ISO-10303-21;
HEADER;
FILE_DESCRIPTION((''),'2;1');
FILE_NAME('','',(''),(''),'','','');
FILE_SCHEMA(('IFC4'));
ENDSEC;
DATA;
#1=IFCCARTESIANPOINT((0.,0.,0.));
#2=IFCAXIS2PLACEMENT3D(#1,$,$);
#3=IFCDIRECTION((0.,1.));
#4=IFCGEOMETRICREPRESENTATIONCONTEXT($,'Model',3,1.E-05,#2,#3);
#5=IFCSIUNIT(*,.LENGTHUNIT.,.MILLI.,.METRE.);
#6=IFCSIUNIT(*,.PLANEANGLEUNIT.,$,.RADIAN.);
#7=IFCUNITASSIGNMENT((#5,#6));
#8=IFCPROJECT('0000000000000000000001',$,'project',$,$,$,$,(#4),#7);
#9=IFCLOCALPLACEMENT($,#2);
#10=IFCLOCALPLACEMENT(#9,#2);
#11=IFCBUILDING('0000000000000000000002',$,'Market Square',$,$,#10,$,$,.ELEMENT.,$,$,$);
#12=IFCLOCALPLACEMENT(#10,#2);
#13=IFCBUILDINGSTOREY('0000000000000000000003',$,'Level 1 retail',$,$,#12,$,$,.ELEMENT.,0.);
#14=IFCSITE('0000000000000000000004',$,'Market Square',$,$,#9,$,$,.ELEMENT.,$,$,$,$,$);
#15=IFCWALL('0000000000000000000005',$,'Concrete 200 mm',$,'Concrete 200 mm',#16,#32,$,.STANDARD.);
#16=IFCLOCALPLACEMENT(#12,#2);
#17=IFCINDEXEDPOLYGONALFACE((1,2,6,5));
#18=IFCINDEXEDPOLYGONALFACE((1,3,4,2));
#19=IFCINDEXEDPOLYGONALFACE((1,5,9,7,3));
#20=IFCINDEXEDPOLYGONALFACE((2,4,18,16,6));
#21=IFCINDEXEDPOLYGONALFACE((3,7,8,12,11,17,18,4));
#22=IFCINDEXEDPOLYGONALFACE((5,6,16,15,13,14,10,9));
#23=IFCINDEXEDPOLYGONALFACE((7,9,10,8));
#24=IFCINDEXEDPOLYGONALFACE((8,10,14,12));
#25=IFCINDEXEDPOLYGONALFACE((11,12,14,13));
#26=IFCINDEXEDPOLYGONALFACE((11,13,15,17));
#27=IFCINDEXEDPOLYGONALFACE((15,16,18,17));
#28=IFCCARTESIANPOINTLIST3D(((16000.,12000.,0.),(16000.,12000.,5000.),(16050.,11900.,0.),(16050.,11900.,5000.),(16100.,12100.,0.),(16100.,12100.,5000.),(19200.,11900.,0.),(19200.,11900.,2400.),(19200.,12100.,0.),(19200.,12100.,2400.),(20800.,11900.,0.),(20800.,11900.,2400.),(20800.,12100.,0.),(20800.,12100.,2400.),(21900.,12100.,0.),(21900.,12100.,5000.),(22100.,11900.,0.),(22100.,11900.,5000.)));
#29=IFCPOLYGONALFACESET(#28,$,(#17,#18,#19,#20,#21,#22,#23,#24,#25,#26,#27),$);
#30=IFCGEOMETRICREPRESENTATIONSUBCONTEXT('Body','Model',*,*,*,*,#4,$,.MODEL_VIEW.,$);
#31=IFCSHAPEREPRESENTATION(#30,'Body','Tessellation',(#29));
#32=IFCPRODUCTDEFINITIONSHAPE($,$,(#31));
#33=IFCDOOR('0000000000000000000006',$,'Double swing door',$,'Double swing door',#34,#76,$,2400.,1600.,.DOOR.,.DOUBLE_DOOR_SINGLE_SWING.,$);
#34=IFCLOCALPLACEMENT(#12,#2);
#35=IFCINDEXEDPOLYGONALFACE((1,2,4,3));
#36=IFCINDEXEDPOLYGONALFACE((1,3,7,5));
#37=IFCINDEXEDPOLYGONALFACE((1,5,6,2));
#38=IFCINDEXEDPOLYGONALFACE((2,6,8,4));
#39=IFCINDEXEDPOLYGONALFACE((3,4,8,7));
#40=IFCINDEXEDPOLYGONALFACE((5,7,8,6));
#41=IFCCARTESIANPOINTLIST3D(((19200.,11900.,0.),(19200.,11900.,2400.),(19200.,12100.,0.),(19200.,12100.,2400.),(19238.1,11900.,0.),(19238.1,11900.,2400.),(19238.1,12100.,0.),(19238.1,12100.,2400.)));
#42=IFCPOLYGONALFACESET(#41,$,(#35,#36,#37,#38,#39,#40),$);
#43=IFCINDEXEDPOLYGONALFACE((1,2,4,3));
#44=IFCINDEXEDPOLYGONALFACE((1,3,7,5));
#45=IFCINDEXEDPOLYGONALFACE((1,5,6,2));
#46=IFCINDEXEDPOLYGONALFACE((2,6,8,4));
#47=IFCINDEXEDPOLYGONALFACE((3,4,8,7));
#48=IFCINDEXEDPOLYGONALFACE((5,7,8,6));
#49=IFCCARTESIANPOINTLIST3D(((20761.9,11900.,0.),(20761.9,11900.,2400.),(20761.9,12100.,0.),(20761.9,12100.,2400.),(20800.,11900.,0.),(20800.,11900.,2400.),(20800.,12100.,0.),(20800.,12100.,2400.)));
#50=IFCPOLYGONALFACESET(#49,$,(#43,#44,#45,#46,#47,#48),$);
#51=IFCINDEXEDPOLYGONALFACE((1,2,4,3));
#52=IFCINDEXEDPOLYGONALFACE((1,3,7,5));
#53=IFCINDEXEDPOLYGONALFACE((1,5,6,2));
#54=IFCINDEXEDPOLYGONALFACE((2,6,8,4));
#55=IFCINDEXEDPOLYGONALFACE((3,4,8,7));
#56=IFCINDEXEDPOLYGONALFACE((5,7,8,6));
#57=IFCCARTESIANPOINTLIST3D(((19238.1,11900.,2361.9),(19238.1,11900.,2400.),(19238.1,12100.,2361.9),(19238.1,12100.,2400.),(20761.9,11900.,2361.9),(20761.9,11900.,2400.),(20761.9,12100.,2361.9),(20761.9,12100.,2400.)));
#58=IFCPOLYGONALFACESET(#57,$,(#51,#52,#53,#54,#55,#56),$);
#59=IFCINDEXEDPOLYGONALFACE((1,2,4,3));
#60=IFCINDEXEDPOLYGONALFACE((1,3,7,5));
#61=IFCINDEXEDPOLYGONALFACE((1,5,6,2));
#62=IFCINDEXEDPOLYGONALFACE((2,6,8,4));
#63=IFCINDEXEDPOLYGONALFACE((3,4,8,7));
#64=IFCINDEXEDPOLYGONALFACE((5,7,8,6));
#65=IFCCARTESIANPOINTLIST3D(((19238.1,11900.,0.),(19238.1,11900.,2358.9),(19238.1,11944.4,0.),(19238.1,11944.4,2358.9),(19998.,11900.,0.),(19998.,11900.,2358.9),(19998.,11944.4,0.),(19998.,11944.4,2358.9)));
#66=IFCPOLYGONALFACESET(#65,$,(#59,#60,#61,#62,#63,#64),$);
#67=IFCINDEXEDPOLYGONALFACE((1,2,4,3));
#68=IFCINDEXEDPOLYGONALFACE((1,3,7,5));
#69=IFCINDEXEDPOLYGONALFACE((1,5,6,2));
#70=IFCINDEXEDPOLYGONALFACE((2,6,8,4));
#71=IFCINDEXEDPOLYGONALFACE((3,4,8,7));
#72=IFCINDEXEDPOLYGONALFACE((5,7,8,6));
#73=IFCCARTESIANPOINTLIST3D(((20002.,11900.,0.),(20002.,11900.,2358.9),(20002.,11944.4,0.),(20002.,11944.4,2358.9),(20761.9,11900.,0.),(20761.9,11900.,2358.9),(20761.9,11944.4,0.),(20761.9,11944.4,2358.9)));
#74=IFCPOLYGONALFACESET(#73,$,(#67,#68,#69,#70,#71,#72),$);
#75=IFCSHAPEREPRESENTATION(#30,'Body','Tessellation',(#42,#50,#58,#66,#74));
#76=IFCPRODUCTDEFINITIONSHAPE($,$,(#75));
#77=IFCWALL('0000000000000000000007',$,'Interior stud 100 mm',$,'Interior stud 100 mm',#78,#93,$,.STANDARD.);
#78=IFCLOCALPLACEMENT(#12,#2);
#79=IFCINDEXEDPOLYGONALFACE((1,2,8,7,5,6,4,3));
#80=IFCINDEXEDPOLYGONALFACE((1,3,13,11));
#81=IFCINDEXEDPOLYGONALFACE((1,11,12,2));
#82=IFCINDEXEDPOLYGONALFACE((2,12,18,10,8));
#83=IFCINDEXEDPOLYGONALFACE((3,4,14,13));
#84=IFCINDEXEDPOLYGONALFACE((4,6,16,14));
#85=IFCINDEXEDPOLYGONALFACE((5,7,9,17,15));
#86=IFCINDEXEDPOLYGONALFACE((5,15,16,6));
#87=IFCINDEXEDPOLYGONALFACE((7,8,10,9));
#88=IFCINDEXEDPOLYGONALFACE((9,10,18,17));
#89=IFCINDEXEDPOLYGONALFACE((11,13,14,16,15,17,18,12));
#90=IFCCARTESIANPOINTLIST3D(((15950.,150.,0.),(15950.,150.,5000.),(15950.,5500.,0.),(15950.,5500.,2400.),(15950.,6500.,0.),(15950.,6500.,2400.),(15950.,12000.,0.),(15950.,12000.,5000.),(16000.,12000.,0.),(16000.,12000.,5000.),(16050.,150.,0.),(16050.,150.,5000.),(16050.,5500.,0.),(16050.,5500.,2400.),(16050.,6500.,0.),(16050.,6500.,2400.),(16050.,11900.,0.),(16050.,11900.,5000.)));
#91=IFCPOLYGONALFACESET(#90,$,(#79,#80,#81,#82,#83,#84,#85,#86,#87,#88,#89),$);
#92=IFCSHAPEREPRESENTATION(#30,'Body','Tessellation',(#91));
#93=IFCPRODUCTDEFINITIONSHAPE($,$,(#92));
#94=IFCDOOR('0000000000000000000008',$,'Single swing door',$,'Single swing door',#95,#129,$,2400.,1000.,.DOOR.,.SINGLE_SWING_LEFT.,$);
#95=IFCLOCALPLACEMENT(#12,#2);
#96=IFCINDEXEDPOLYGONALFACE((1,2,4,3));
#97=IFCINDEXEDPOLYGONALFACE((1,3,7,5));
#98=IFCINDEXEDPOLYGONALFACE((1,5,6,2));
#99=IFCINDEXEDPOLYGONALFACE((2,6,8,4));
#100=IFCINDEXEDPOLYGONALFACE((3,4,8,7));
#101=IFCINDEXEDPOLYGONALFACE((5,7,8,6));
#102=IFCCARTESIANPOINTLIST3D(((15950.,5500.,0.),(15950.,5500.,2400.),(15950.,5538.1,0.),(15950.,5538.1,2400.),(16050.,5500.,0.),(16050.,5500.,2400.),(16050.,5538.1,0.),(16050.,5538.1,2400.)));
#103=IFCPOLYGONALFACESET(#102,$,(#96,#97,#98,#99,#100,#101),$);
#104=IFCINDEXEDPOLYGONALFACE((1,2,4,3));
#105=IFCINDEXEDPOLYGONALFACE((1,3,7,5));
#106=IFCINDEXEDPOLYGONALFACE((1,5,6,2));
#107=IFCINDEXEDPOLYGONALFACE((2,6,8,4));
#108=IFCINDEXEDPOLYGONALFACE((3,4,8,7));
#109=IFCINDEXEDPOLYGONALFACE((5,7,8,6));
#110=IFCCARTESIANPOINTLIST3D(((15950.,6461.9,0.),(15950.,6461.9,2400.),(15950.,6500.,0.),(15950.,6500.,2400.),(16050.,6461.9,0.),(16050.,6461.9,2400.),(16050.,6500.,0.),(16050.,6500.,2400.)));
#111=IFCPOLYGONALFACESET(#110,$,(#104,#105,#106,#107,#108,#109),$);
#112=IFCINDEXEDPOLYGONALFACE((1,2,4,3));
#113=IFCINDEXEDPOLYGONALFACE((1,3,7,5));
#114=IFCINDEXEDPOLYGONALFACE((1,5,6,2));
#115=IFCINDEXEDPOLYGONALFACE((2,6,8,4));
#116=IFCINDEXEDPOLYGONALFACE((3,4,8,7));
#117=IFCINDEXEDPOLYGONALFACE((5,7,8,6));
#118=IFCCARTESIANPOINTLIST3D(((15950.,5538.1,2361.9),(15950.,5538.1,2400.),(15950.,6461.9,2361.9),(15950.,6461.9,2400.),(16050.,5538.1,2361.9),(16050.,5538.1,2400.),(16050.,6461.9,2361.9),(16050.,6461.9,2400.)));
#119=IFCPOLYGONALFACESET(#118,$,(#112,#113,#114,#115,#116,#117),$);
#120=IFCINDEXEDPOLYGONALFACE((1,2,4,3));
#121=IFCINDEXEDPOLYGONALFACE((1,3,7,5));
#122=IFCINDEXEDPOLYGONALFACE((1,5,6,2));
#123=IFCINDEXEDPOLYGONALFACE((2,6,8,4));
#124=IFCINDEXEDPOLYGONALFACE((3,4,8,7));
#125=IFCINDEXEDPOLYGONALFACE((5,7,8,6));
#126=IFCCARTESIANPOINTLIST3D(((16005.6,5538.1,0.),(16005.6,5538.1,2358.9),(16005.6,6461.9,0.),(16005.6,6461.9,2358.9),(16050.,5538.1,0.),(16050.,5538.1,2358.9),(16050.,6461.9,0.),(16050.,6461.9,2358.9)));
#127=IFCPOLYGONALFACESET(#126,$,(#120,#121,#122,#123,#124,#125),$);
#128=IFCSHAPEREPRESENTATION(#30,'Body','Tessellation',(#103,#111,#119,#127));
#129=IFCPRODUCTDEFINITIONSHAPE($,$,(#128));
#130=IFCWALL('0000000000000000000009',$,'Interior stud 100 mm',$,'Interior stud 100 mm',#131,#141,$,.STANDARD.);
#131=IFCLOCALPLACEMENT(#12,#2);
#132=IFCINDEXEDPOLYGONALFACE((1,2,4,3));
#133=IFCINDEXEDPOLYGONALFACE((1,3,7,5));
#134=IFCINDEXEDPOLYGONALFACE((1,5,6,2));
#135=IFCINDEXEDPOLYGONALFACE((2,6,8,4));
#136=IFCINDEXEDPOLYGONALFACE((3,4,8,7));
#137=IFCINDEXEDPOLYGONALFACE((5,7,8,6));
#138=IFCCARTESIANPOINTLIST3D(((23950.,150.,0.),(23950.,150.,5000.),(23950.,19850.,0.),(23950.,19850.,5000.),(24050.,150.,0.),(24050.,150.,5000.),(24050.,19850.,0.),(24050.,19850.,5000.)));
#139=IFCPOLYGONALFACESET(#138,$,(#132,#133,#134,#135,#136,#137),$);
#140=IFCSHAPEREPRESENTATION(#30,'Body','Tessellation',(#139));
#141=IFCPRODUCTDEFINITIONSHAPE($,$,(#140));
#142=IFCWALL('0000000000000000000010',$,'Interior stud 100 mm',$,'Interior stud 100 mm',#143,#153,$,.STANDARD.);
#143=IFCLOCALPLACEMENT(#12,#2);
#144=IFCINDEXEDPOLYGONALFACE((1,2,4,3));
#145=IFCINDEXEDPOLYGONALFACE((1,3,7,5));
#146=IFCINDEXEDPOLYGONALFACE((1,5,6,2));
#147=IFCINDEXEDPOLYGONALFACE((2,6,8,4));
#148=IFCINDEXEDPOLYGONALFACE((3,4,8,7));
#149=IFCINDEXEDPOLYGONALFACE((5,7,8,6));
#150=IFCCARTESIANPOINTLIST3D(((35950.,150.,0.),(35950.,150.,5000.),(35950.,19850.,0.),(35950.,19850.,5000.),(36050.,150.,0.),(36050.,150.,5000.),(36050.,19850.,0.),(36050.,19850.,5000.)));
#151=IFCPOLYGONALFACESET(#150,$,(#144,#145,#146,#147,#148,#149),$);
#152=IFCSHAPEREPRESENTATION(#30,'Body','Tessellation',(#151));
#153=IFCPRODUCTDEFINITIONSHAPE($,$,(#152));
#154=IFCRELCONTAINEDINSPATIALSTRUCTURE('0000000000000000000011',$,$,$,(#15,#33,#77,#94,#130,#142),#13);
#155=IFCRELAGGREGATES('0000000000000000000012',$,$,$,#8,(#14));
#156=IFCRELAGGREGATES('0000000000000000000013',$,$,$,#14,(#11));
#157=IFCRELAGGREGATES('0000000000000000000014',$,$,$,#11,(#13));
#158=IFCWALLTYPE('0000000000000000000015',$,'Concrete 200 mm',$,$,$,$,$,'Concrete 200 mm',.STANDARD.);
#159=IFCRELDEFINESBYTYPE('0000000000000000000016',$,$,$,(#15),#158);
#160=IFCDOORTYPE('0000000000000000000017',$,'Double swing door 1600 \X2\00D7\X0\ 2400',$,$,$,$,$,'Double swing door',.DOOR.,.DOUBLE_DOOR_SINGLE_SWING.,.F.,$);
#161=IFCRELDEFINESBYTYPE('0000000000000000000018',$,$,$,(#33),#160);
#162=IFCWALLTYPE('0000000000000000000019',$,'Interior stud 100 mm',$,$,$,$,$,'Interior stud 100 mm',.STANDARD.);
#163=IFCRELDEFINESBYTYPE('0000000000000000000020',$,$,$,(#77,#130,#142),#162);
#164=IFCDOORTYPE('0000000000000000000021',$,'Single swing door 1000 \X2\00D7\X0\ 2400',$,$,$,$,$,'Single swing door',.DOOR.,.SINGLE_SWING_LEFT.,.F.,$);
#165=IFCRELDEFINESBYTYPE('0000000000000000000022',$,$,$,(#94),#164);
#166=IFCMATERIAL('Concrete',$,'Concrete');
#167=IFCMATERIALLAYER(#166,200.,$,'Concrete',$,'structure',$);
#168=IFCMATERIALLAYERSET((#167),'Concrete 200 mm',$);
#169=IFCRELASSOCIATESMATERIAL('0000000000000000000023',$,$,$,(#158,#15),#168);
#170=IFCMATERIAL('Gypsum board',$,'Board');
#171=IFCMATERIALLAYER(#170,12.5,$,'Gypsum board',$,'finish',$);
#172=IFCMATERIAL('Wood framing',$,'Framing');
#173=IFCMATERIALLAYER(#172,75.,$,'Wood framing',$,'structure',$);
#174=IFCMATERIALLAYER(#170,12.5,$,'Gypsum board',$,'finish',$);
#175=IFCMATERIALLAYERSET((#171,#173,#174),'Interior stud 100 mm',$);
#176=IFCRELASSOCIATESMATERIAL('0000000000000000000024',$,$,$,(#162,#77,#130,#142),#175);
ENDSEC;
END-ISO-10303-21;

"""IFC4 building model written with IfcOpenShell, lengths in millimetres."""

from ifc_helpers import new_model, si_unit, direction, frame, origin, origin_with_axes, place, context, subcontext, project, spatial, polyline, outline, extrude, material, layer, layer_set, layer_usage, type_object, element, fill, save


model = new_model("IFC4")

# Units and contexts
model_context = context("Model", 3, precision=1e-05, world=origin(), true_north=direction((0.0, 1.0)))
body_context = subcontext(model_context, "Body", "Model", "MODEL_VIEW")
ifc_project = project(units=[si_unit("LENGTHUNIT", "METRE", prefix="MILLI"), si_unit("PLANEANGLEUNIT", "RADIAN")], contexts=[model_context])

# Site, building, storey
site_placement = place(None, origin())
site = spatial("IfcSite", under=ifc_project, at=site_placement, Name="Market Square", CompositionType="ELEMENT")
building_placement = place(site_placement, origin())
building = spatial("IfcBuilding", under=site, at=building_placement, Name="Market Square", CompositionType="ELEMENT")
storey_placement = place(building_placement, origin())
storey = spatial("IfcBuildingStorey", under=building, at=storey_placement, Name="Level 1 retail", CompositionType="ELEMENT", Elevation=0.0)

# Shared definitions
door_type_1 = type_object("IfcDoorType", Name="Single swing door 1000 × 2400", ElementType="Single swing door", OperationType="SINGLE_SWING_LEFT", ParameterTakesPrecedence=False, PredefinedType="DOOR")

# Shared definitions
ifc_material_1 = material(Name="Concrete", Category="Concrete")
ifc_layer_1 = layer(ifc_material_1, 200.0, Name="Concrete", Category="structure")
ifc_layer_set_1 = layer_set([ifc_layer_1], Name="Concrete 200 mm")
wall_type_1 = type_object("IfcWallType", Name="Concrete 200 mm", ElementType="Concrete 200 mm", PredefinedType="STANDARD", material=ifc_layer_set_1)

# Walls, openings, doors
ifc_layer_usage_1 = layer_usage(ifc_layer_set_1, "AXIS2", "NEGATIVE", 100.0)
wall_1_placement = place(storey_placement, frame((16000.0, 12000.0, 0.0), z_axis=(0.0, 0.0, 1.0), x_axis=(1.0, 0.0, 0.0)))
wall_1 = element("IfcWall", 1, at=wall_1_placement, inside=storey, type_object=wall_type_1, material=ifc_layer_usage_1, Name="Concrete 200 mm", ObjectType="Concrete 200 mm", PredefinedType="STANDARD", context=body_context, shape_type="SweptSolid", body=[
    extrude(outline(polyline([(50.0, -100.0), (6100.0, -100.0), (5900.0, 100.0), (100.0, 100.0), (0.0, 0.0), (50.0, -100.0)])), origin(), (0.0, 0.0, 1.0), 5000.0),
])
opening_1_placement = place(wall_1_placement, frame((3200.0, 0.0, 0.0), z_axis=(0.0, 0.0, 1.0), x_axis=(1.0, 0.0, 0.0)))
opening_1 = element("IfcOpeningElement", 2, at=opening_1_placement, cuts=wall_1, PredefinedType="OPENING", context=body_context, shape_type="SweptSolid", body=[
    extrude(outline(polyline([(0.0, -110.0), (1600.0, -110.0), (1600.0, 110.0), (0.0, 110.0), (0.0, -110.0)])), origin(), (0.0, 0.0, 1.0), 2400.0),
])
door_type_2 = type_object("IfcDoorType", Name="Double swing door 1600 × 2400", ElementType="Double swing door", OperationType="DOUBLE_DOOR_SINGLE_SWING", ParameterTakesPrecedence=False, PredefinedType="DOOR")
door_1_placement = place(opening_1_placement, origin_with_axes())
door_1 = element("IfcDoor", 3, at=door_1_placement, inside=storey, type_object=door_type_2, Name="Double swing door", ObjectType="Double swing door", OperationType="DOUBLE_DOOR_SINGLE_SWING", OverallHeight=2400.0, OverallWidth=1600.0, PredefinedType="DOOR", context=body_context, shape_type="SweptSolid", body=[
    extrude(outline(polyline([(0.0, -100.0), (38.1, -100.0), (38.1, 100.0), (0.0, 100.0), (0.0, -100.0)])), origin(), (0.0, 0.0, 1.0), 2400.0),
    extrude(outline(polyline([(1561.9, -100.0), (1600.0, -100.0), (1600.0, 100.0), (1561.9, 100.0), (1561.9, -100.0)])), origin(), (0.0, 0.0, 1.0), 2400.0),
    extrude(outline(polyline([(38.1, -100.0), (1561.9, -100.0), (1561.9, 100.0), (38.1, 100.0), (38.1, -100.0)])), frame((0.0, 0.0, 2361.9)), (0.0, 0.0, 1.0), 38.1),
    extrude(outline(polyline([(38.1, -100.0), (798.0, -100.0), (798.0, -55.5), (38.1, -55.5), (38.1, -100.0)])), origin(), (0.0, 0.0, 1.0), 2358.9),
    extrude(outline(polyline([(802.0, -100.0), (1561.9, -100.0), (1561.9, -55.5), (802.0, -55.5), (802.0, -100.0)])), origin(), (0.0, 0.0, 1.0), 2358.9),
])
fill(opening_1, door_1)
ifc_material_2 = material(Name="Gypsum board", Category="Board")
ifc_layer_2 = layer(ifc_material_2, 12.5, Name="Gypsum board", Category="finish")
ifc_material_3 = material(Name="Wood framing", Category="Framing")
ifc_layer_3 = layer(ifc_material_3, 75.0, Name="Wood framing", Category="structure")
ifc_layer_4 = layer(ifc_material_2, 12.5, Name="Gypsum board", Category="finish")
ifc_layer_set_2 = layer_set([ifc_layer_2, ifc_layer_3, ifc_layer_4], Name="Interior stud 100 mm")
ifc_layer_usage_2 = layer_usage(ifc_layer_set_2, "AXIS2", "NEGATIVE", 50.0)
wall_type_2 = type_object("IfcWallType", Name="Interior stud 100 mm", ElementType="Interior stud 100 mm", PredefinedType="STANDARD", material=ifc_layer_set_2)
wall_2_placement = place(storey_placement, frame((16000.0, 0.0, 0.0), z_axis=(0.0, 0.0, 1.0), x_axis=(0.0, 1.0, 0.0)))
wall_2 = element("IfcWall", 4, at=wall_2_placement, inside=storey, type_object=wall_type_2, material=ifc_layer_usage_2, Name="Interior stud 100 mm", ObjectType="Interior stud 100 mm", PredefinedType="STANDARD", context=body_context, shape_type="SweptSolid", body=[
    extrude(outline(polyline([(150.0, -50.0), (11900.0, -50.0), (12000.0, 0.0), (12000.0, 50.0), (150.0, 50.0), (150.0, -50.0)])), origin(), (0.0, 0.0, 1.0), 5000.0),
])
opening_2_placement = place(wall_2_placement, frame((5500.0, 0.0, 0.0), z_axis=(0.0, 0.0, 1.0), x_axis=(1.0, 0.0, 0.0)))
opening_2 = element("IfcOpeningElement", 5, at=opening_2_placement, cuts=wall_2, PredefinedType="OPENING", context=body_context, shape_type="SweptSolid", body=[
    extrude(outline(polyline([(0.0, -60.0), (1000.0, -60.0), (1000.0, 60.0), (0.0, 60.0), (0.0, -60.0)])), origin(), (0.0, 0.0, 1.0), 2400.0),
])
door_2_placement = place(opening_2_placement, origin_with_axes())
door_2 = element("IfcDoor", 6, at=door_2_placement, inside=storey, type_object=door_type_1, Name="Single swing door", ObjectType="Single swing door", OperationType="SINGLE_SWING_LEFT", OverallHeight=2400.0, OverallWidth=1000.0, PredefinedType="DOOR", context=body_context, shape_type="SweptSolid", body=[
    extrude(outline(polyline([(0.0, -50.0), (38.1, -50.0), (38.1, 50.0), (0.0, 50.0), (0.0, -50.0)])), origin(), (0.0, 0.0, 1.0), 2400.0),
    extrude(outline(polyline([(961.9, -50.0), (1000.0, -50.0), (1000.0, 50.0), (961.9, 50.0), (961.9, -50.0)])), origin(), (0.0, 0.0, 1.0), 2400.0),
    extrude(outline(polyline([(38.1, -50.0), (961.9, -50.0), (961.9, 50.0), (38.1, 50.0), (38.1, -50.0)])), frame((0.0, 0.0, 2361.9)), (0.0, 0.0, 1.0), 38.1),
    extrude(outline(polyline([(38.1, -50.0), (961.9, -50.0), (961.9, -5.5), (38.1, -5.5), (38.1, -50.0)])), origin(), (0.0, 0.0, 1.0), 2358.9),
])
fill(opening_2, door_2)

# Walls
ifc_layer_usage_3 = layer_usage(ifc_layer_set_2, "AXIS2", "NEGATIVE", 50.0)
wall_3_placement = place(storey_placement, frame((24000.0, 0.0, 0.0), z_axis=(0.0, 0.0, 1.0), x_axis=(0.0, 1.0, 0.0)))
element("IfcWall", 7, at=wall_3_placement, inside=storey, type_object=wall_type_2, material=ifc_layer_usage_3, Name="Interior stud 100 mm", ObjectType="Interior stud 100 mm", PredefinedType="STANDARD", context=body_context, shape_type="SweptSolid", body=[
    extrude(outline(polyline([(150.0, -50.0), (19850.0, -50.0), (19850.0, 50.0), (150.0, 50.0), (150.0, -50.0)])), origin(), (0.0, 0.0, 1.0), 5000.0),
])
ifc_layer_usage_4 = layer_usage(ifc_layer_set_2, "AXIS2", "NEGATIVE", 50.0)
wall_4_placement = place(storey_placement, frame((36000.0, 0.0, 0.0), z_axis=(0.0, 0.0, 1.0), x_axis=(0.0, 1.0, 0.0)))
element("IfcWall", 8, at=wall_4_placement, inside=storey, type_object=wall_type_2, material=ifc_layer_usage_4, Name="Interior stud 100 mm", ObjectType="Interior stud 100 mm", PredefinedType="STANDARD", context=body_context, shape_type="SweptSolid", body=[
    extrude(outline(polyline([(150.0, -50.0), (19850.0, -50.0), (19850.0, 50.0), (150.0, 50.0), (150.0, -50.0)])), origin(), (0.0, 0.0, 1.0), 5000.0),
])

save(model, "model.ifc")
